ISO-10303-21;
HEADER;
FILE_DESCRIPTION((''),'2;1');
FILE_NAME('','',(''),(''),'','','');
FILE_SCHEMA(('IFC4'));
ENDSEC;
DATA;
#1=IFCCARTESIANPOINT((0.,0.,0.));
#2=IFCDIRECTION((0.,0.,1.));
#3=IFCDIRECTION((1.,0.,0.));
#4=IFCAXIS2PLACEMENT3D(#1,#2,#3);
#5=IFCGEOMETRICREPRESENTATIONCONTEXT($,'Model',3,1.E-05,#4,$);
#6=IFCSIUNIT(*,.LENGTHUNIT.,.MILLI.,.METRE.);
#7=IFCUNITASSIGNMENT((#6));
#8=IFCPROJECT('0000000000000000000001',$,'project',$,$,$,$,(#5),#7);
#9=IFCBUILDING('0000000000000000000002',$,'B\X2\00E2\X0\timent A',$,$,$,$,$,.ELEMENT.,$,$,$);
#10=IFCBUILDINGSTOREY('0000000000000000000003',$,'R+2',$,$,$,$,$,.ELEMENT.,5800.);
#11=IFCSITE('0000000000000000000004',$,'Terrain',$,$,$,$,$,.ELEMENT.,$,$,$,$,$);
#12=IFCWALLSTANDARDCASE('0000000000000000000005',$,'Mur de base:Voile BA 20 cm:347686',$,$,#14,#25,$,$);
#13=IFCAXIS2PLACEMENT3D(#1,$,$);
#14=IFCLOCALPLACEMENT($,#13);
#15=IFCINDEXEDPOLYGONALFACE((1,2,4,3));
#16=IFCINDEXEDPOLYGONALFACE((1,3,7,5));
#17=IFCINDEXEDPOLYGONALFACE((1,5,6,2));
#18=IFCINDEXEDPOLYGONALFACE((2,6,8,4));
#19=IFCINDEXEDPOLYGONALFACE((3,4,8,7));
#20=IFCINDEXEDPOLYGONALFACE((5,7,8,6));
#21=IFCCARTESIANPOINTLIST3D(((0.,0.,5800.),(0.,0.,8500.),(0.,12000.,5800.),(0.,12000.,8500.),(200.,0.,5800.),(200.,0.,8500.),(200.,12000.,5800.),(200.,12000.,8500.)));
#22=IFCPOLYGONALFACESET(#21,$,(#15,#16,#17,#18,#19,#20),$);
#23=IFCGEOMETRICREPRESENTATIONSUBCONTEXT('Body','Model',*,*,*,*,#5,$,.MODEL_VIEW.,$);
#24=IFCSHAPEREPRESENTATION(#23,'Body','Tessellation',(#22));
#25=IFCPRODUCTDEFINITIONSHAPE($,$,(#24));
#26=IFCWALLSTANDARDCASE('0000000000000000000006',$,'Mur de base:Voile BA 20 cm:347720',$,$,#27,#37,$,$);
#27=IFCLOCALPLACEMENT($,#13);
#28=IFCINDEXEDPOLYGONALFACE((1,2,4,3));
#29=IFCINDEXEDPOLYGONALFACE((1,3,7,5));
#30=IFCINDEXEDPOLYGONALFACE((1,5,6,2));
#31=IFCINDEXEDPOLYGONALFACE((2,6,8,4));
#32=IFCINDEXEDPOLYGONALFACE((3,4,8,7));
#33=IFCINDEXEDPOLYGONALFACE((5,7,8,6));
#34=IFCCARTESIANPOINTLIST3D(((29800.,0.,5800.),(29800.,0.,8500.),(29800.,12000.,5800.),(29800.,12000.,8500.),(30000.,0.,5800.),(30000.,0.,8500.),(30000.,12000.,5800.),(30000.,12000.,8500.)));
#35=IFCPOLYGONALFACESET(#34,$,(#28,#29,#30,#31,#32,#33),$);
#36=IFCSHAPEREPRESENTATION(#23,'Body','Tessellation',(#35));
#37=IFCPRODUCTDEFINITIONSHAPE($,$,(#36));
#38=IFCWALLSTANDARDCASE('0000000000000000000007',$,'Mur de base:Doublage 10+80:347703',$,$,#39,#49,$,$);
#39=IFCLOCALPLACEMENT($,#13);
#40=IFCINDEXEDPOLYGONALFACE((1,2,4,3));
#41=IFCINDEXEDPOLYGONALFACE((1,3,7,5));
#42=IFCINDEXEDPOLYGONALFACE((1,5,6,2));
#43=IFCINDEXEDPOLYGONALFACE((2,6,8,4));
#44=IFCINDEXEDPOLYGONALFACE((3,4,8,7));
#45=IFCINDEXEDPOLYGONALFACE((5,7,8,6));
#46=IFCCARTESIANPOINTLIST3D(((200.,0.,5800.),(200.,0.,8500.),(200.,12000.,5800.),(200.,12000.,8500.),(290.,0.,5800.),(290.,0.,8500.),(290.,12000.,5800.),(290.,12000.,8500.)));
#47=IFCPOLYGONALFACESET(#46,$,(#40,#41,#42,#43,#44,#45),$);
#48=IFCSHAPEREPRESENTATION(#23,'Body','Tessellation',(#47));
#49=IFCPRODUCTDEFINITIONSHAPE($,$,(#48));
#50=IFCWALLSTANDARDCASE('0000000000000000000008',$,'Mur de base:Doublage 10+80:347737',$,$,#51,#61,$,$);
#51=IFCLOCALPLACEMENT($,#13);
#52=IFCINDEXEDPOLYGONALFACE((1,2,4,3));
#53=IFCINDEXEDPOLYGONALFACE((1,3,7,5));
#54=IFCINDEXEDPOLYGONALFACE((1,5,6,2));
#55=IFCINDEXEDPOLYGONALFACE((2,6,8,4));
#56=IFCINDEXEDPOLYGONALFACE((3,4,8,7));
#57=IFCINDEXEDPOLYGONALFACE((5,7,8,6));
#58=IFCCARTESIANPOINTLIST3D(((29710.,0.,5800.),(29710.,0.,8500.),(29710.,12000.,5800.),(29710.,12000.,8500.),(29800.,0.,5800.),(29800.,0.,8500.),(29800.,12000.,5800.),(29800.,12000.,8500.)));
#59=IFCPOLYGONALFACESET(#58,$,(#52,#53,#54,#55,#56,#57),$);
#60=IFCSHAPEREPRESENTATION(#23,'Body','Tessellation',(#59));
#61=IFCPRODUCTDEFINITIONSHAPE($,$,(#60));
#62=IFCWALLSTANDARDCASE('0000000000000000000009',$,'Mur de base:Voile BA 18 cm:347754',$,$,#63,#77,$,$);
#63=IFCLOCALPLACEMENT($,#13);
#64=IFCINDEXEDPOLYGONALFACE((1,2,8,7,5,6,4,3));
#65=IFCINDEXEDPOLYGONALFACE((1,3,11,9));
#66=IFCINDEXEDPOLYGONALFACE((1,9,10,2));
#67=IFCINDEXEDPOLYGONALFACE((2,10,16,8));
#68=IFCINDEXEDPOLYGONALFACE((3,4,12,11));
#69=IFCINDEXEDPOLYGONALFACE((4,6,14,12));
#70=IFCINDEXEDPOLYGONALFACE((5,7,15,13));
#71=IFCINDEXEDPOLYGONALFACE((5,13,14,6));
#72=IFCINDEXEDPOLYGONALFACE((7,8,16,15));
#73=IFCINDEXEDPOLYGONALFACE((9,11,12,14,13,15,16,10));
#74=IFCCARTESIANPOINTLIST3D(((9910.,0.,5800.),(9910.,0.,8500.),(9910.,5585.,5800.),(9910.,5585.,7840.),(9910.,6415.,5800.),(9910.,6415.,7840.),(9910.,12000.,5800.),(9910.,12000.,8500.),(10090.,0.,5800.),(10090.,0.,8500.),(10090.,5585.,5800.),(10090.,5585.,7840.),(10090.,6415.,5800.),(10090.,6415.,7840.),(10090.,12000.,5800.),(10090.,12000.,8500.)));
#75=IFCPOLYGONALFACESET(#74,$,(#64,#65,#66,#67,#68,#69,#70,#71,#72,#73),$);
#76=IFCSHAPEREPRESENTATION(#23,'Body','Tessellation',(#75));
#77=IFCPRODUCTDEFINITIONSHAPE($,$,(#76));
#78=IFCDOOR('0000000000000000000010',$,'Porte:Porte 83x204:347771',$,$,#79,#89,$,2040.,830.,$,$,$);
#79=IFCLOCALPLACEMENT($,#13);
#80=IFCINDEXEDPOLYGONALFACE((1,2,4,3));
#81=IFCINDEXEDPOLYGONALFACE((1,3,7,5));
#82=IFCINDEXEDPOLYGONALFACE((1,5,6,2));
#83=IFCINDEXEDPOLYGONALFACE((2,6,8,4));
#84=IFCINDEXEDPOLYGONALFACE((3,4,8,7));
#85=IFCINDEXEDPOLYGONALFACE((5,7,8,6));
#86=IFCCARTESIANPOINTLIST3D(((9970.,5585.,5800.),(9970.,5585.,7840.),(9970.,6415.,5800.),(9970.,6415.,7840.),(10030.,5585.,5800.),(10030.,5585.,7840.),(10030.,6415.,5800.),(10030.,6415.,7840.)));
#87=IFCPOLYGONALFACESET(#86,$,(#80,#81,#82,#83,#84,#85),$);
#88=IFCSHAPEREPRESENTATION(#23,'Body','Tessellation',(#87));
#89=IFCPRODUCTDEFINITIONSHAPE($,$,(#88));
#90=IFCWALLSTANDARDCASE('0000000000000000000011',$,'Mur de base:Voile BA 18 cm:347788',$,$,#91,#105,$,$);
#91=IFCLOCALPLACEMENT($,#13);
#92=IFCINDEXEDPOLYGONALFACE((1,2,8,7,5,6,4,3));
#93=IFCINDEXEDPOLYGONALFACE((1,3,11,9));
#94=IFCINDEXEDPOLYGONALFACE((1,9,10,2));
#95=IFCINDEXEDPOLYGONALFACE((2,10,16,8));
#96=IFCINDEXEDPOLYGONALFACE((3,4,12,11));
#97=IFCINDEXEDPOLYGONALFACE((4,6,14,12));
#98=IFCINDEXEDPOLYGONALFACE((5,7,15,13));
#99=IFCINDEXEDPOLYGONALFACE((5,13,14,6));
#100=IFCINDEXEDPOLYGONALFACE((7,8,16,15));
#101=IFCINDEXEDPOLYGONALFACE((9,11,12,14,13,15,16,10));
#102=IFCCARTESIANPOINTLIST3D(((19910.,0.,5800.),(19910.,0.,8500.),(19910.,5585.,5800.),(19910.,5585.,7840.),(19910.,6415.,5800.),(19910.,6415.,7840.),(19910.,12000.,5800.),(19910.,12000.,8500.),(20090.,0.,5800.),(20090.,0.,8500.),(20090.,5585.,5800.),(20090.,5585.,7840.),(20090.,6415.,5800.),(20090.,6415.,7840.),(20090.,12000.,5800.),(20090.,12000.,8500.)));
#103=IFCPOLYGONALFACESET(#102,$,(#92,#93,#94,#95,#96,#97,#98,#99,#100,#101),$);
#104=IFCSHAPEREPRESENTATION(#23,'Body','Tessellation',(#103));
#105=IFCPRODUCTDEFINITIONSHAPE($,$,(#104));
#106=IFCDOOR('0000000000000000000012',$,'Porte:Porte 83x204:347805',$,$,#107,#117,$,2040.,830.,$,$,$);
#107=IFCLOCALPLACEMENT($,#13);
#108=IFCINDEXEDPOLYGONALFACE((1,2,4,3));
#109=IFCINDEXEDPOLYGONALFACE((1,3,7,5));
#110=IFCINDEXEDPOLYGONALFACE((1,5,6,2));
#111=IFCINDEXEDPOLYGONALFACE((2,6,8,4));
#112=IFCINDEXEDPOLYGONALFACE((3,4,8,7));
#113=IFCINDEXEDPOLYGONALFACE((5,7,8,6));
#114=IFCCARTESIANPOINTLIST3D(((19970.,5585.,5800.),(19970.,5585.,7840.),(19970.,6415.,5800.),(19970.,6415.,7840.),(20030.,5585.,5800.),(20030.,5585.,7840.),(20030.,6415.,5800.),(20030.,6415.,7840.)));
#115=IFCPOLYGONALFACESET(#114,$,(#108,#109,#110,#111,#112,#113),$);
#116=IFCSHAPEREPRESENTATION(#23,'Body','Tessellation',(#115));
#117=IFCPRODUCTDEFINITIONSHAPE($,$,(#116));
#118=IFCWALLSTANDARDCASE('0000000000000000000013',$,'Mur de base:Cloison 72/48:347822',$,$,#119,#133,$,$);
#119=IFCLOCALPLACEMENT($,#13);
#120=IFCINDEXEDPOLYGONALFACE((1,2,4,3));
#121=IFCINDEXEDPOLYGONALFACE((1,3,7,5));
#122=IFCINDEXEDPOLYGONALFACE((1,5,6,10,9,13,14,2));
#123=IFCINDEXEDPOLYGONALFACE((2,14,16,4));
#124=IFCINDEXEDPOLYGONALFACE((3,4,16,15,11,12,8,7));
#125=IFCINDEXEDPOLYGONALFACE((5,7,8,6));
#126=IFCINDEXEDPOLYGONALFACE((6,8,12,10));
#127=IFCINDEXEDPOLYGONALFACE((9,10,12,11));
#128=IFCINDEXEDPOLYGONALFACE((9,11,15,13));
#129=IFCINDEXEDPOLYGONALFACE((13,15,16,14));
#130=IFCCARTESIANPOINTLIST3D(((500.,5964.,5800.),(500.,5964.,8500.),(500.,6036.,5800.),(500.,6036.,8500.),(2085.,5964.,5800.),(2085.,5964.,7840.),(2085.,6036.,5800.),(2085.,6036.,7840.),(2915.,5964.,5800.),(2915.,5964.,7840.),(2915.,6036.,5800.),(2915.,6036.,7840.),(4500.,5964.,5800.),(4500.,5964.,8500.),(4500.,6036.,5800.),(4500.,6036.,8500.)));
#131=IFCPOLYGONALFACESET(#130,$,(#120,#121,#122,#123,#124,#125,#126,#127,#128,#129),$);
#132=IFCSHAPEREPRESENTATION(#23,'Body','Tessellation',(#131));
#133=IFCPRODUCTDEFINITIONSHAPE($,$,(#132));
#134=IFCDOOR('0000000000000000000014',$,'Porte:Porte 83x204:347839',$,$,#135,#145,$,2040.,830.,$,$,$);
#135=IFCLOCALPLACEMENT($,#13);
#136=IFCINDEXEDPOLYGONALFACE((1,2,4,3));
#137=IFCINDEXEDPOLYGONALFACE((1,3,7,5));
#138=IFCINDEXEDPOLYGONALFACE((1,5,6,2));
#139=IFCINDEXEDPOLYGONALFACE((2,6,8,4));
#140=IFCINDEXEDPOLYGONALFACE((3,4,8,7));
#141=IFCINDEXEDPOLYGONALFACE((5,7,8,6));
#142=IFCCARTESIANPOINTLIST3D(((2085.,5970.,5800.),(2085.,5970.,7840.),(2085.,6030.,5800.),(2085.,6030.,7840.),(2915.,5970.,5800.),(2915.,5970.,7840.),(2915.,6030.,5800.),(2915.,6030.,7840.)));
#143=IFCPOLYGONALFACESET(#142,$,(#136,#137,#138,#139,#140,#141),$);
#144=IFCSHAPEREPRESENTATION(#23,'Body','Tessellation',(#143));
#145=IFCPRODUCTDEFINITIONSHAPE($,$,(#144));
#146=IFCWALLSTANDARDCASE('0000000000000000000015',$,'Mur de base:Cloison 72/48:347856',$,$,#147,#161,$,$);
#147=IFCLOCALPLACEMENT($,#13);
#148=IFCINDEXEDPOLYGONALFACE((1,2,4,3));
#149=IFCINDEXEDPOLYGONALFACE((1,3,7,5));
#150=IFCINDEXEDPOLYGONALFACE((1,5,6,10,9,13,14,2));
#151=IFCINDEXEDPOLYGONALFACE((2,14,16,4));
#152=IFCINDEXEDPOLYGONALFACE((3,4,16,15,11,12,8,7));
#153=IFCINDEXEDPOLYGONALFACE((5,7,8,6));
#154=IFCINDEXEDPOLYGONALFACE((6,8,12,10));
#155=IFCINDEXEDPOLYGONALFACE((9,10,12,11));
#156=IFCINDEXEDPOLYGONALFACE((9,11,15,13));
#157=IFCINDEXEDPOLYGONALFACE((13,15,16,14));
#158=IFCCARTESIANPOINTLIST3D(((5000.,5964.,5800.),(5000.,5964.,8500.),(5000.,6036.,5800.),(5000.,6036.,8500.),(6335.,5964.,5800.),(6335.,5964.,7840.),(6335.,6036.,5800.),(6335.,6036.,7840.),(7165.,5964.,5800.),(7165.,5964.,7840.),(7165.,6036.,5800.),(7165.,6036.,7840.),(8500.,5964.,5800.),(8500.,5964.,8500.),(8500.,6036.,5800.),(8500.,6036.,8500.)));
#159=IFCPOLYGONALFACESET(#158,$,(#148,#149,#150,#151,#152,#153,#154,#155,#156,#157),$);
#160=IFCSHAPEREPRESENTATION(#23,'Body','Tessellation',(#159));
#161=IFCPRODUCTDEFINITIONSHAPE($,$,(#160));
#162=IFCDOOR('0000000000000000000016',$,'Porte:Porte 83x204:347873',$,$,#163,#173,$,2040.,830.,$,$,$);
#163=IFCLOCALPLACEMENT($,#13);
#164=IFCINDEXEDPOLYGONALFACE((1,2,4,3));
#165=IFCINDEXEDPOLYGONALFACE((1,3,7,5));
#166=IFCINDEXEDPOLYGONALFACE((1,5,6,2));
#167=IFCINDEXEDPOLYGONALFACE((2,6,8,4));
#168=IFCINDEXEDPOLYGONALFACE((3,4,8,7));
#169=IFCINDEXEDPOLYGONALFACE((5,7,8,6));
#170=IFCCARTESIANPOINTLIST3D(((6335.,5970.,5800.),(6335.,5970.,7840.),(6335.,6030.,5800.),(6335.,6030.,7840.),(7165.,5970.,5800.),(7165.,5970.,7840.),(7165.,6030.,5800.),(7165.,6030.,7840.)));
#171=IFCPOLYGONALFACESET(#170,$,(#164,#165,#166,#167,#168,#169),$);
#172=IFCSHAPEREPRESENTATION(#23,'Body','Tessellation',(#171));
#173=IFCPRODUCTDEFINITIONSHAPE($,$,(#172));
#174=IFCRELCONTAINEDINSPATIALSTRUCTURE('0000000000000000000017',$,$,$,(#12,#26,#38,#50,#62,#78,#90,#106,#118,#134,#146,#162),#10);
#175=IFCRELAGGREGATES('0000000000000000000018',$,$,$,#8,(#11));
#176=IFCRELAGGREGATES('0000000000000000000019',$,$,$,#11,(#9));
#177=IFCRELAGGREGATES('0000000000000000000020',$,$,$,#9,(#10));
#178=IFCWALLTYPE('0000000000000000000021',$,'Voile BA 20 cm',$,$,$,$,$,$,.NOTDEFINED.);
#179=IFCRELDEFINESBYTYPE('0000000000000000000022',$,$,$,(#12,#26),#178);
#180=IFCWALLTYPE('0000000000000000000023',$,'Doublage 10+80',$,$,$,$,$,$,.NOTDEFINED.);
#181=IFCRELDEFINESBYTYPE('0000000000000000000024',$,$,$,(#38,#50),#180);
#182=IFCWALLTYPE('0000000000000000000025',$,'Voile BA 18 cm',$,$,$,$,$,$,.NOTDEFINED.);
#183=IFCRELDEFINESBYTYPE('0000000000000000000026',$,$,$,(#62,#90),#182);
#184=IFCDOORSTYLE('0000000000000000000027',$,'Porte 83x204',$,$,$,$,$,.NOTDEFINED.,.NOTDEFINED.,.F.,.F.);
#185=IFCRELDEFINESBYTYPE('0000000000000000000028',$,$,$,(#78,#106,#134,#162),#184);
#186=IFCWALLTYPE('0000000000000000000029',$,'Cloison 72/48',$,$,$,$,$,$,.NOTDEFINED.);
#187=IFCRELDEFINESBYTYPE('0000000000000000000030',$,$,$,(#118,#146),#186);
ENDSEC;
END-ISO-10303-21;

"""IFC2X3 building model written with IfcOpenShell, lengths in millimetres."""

from ifc_helpers import new_model, si_unit, frame, frame_2d, origin_with_axes, place, context, subcontext, project, spatial, rectangle, extrude, type_object, element, fill, save


model = new_model("IFC2X3")

# Units and contexts
model_context = context("Model", 3, precision=1e-05, world=origin_with_axes())
body_context = subcontext(model_context, "Body", "Model", "MODEL_VIEW")
ifc_project = project(units=[si_unit("LENGTHUNIT", "METRE", prefix="MILLI")], contexts=[model_context])

# Site, building, storey
site = spatial("IfcSite", under=ifc_project, Name="Terrain", CompositionType="ELEMENT")
building = spatial("IfcBuilding", under=site, Name="Bâtiment A", CompositionType="ELEMENT")
storey = spatial("IfcBuildingStorey", under=building, Name="R+2", CompositionType="ELEMENT", Elevation=5800.0)

# Walls
wall_type_1 = type_object("IfcWallType", Name="Voile BA 20 cm", PredefinedType="NOTDEFINED")
wall_1_placement = place(None, origin_with_axes())
element("IfcWallStandardCase", 1, at=wall_1_placement, inside=storey, type_object=wall_type_1, Name="Mur de base:Voile BA 20 cm:347686", context=body_context, shape_type="SweptSolid", body=[
    extrude(rectangle(XDim=200.0, YDim=12000.0, at=frame_2d((100.0, 6000.0))), frame((0.0, 0.0, 5800.0), z_axis=(0.0, 0.0, 1.0), x_axis=(1.0, 0.0, 0.0)), (0.0, 0.0, 1.0), 2700.0),
])
wall_2_placement = place(None, origin_with_axes())
element("IfcWallStandardCase", 2, at=wall_2_placement, inside=storey, type_object=wall_type_1, Name="Mur de base:Voile BA 20 cm:347720", context=body_context, shape_type="SweptSolid", body=[
    extrude(rectangle(XDim=200.0, YDim=12000.0, at=frame_2d((29900.0, 6000.0))), frame((0.0, 0.0, 5800.0), z_axis=(0.0, 0.0, 1.0), x_axis=(1.0, 0.0, 0.0)), (0.0, 0.0, 1.0), 2700.0),
])
wall_type_2 = type_object("IfcWallType", Name="Doublage 10+80", PredefinedType="NOTDEFINED")
wall_3_placement = place(None, origin_with_axes())
element("IfcWallStandardCase", 3, at=wall_3_placement, inside=storey, type_object=wall_type_2, Name="Mur de base:Doublage 10+80:347703", context=body_context, shape_type="SweptSolid", body=[
    extrude(rectangle(XDim=90.0, YDim=12000.0, at=frame_2d((245.0, 6000.0))), frame((0.0, 0.0, 5800.0), z_axis=(0.0, 0.0, 1.0), x_axis=(1.0, 0.0, 0.0)), (0.0, 0.0, 1.0), 2700.0),
])
wall_4_placement = place(None, origin_with_axes())
element("IfcWallStandardCase", 4, at=wall_4_placement, inside=storey, type_object=wall_type_2, Name="Mur de base:Doublage 10+80:347737", context=body_context, shape_type="SweptSolid", body=[
    extrude(rectangle(XDim=90.0, YDim=12000.0, at=frame_2d((29755.0, 6000.0))), frame((0.0, 0.0, 5800.0), z_axis=(0.0, 0.0, 1.0), x_axis=(1.0, 0.0, 0.0)), (0.0, 0.0, 1.0), 2700.0),
])

# Walls, openings, doors
wall_type_3 = type_object("IfcWallType", Name="Voile BA 18 cm", PredefinedType="NOTDEFINED")
wall_5_placement = place(None, origin_with_axes())
wall_5 = element("IfcWallStandardCase", 5, at=wall_5_placement, inside=storey, type_object=wall_type_3, Name="Mur de base:Voile BA 18 cm:347754", context=body_context, shape_type="SweptSolid", body=[
    extrude(rectangle(XDim=180.0, YDim=12000.0, at=frame_2d((10000.0, 6000.0))), frame((0.0, 0.0, 5800.0), z_axis=(0.0, 0.0, 1.0), x_axis=(1.0, 0.0, 0.0)), (0.0, 0.0, 1.0), 2700.0),
])
opening_1_placement = place(None, origin_with_axes())
opening_1 = element("IfcOpeningElement", 6, at=opening_1_placement, cuts=wall_5, context=body_context, shape_type="SweptSolid", body=[
    extrude(rectangle(XDim=300.0, YDim=830.0, at=frame_2d((10000.0, 6000.0))), frame((0.0, 0.0, 5800.0), z_axis=(0.0, 0.0, 1.0), x_axis=(1.0, 0.0, 0.0)), (0.0, 0.0, 1.0), 2040.0),
])
door_style = type_object("IfcDoorStyle", Name="Porte 83x204", ConstructionType="NOTDEFINED", OperationType="NOTDEFINED", ParameterTakesPrecedence=False, Sizeable=False)
door_1_placement = place(None, origin_with_axes())
door_1 = element("IfcDoor", 7, at=door_1_placement, inside=storey, type_object=door_style, Name="Porte:Porte 83x204:347771", OverallHeight=2040.0, OverallWidth=830.0, context=body_context, shape_type="SweptSolid", body=[
    extrude(rectangle(XDim=60.0, YDim=830.0, at=frame_2d((10000.0, 6000.0))), frame((0.0, 0.0, 5800.0), z_axis=(0.0, 0.0, 1.0), x_axis=(1.0, 0.0, 0.0)), (0.0, 0.0, 1.0), 2040.0),
])
fill(opening_1, door_1)
wall_6_placement = place(None, origin_with_axes())
wall_6 = element("IfcWallStandardCase", 8, at=wall_6_placement, inside=storey, type_object=wall_type_3, Name="Mur de base:Voile BA 18 cm:347788", context=body_context, shape_type="SweptSolid", body=[
    extrude(rectangle(XDim=180.0, YDim=12000.0, at=frame_2d((20000.0, 6000.0))), frame((0.0, 0.0, 5800.0), z_axis=(0.0, 0.0, 1.0), x_axis=(1.0, 0.0, 0.0)), (0.0, 0.0, 1.0), 2700.0),
])
opening_2_placement = place(None, origin_with_axes())
opening_2 = element("IfcOpeningElement", 9, at=opening_2_placement, cuts=wall_6, context=body_context, shape_type="SweptSolid", body=[
    extrude(rectangle(XDim=300.0, YDim=830.0, at=frame_2d((20000.0, 6000.0))), frame((0.0, 0.0, 5800.0), z_axis=(0.0, 0.0, 1.0), x_axis=(1.0, 0.0, 0.0)), (0.0, 0.0, 1.0), 2040.0),
])
door_2_placement = place(None, origin_with_axes())
door_2 = element("IfcDoor", 10, at=door_2_placement, inside=storey, type_object=door_style, Name="Porte:Porte 83x204:347805", OverallHeight=2040.0, OverallWidth=830.0, context=body_context, shape_type="SweptSolid", body=[
    extrude(rectangle(XDim=60.0, YDim=830.0, at=frame_2d((20000.0, 6000.0))), frame((0.0, 0.0, 5800.0), z_axis=(0.0, 0.0, 1.0), x_axis=(1.0, 0.0, 0.0)), (0.0, 0.0, 1.0), 2040.0),
])
fill(opening_2, door_2)
wall_type_4 = type_object("IfcWallType", Name="Cloison 72/48", PredefinedType="NOTDEFINED")
wall_7_placement = place(None, origin_with_axes())
wall_7 = element("IfcWallStandardCase", 11, at=wall_7_placement, inside=storey, type_object=wall_type_4, Name="Mur de base:Cloison 72/48:347822", context=body_context, shape_type="SweptSolid", body=[
    extrude(rectangle(XDim=4000.0, YDim=72.0, at=frame_2d((2500.0, 6000.0))), frame((0.0, 0.0, 5800.0), z_axis=(0.0, 0.0, 1.0), x_axis=(1.0, 0.0, 0.0)), (0.0, 0.0, 1.0), 2700.0),
])
opening_3_placement = place(None, origin_with_axes())
opening_3 = element("IfcOpeningElement", 12, at=opening_3_placement, cuts=wall_7, context=body_context, shape_type="SweptSolid", body=[
    extrude(rectangle(XDim=830.0, YDim=192.0, at=frame_2d((2500.0, 6000.0))), frame((0.0, 0.0, 5800.0), z_axis=(0.0, 0.0, 1.0), x_axis=(1.0, 0.0, 0.0)), (0.0, 0.0, 1.0), 2040.0),
])
door_3_placement = place(None, origin_with_axes())
door_3 = element("IfcDoor", 13, at=door_3_placement, inside=storey, type_object=door_style, Name="Porte:Porte 83x204:347839", OverallHeight=2040.0, OverallWidth=830.0, context=body_context, shape_type="SweptSolid", body=[
    extrude(rectangle(XDim=830.0, YDim=60.0, at=frame_2d((2500.0, 6000.0))), frame((0.0, 0.0, 5800.0), z_axis=(0.0, 0.0, 1.0), x_axis=(1.0, 0.0, 0.0)), (0.0, 0.0, 1.0), 2040.0),
])
fill(opening_3, door_3)
wall_8_placement = place(None, origin_with_axes())
wall_8 = element("IfcWallStandardCase", 14, at=wall_8_placement, inside=storey, type_object=wall_type_4, Name="Mur de base:Cloison 72/48:347856", context=body_context, shape_type="SweptSolid", body=[
    extrude(rectangle(XDim=3500.0, YDim=72.0, at=frame_2d((6750.0, 6000.0))), frame((0.0, 0.0, 5800.0), z_axis=(0.0, 0.0, 1.0), x_axis=(1.0, 0.0, 0.0)), (0.0, 0.0, 1.0), 2700.0),
])
opening_4_placement = place(None, origin_with_axes())
opening_4 = element("IfcOpeningElement", 15, at=opening_4_placement, cuts=wall_8, context=body_context, shape_type="SweptSolid", body=[
    extrude(rectangle(XDim=830.0, YDim=192.0, at=frame_2d((6750.0, 6000.0))), frame((0.0, 0.0, 5800.0), z_axis=(0.0, 0.0, 1.0), x_axis=(1.0, 0.0, 0.0)), (0.0, 0.0, 1.0), 2040.0),
])
door_4_placement = place(None, origin_with_axes())
door_4 = element("IfcDoor", 16, at=door_4_placement, inside=storey, type_object=door_style, Name="Porte:Porte 83x204:347873", OverallHeight=2040.0, OverallWidth=830.0, context=body_context, shape_type="SweptSolid", body=[
    extrude(rectangle(XDim=830.0, YDim=60.0, at=frame_2d((6750.0, 6000.0))), frame((0.0, 0.0, 5800.0), z_axis=(0.0, 0.0, 1.0), x_axis=(1.0, 0.0, 0.0)), (0.0, 0.0, 1.0), 2040.0),
])
fill(opening_4, door_4)

save(model, "model.ifc")
